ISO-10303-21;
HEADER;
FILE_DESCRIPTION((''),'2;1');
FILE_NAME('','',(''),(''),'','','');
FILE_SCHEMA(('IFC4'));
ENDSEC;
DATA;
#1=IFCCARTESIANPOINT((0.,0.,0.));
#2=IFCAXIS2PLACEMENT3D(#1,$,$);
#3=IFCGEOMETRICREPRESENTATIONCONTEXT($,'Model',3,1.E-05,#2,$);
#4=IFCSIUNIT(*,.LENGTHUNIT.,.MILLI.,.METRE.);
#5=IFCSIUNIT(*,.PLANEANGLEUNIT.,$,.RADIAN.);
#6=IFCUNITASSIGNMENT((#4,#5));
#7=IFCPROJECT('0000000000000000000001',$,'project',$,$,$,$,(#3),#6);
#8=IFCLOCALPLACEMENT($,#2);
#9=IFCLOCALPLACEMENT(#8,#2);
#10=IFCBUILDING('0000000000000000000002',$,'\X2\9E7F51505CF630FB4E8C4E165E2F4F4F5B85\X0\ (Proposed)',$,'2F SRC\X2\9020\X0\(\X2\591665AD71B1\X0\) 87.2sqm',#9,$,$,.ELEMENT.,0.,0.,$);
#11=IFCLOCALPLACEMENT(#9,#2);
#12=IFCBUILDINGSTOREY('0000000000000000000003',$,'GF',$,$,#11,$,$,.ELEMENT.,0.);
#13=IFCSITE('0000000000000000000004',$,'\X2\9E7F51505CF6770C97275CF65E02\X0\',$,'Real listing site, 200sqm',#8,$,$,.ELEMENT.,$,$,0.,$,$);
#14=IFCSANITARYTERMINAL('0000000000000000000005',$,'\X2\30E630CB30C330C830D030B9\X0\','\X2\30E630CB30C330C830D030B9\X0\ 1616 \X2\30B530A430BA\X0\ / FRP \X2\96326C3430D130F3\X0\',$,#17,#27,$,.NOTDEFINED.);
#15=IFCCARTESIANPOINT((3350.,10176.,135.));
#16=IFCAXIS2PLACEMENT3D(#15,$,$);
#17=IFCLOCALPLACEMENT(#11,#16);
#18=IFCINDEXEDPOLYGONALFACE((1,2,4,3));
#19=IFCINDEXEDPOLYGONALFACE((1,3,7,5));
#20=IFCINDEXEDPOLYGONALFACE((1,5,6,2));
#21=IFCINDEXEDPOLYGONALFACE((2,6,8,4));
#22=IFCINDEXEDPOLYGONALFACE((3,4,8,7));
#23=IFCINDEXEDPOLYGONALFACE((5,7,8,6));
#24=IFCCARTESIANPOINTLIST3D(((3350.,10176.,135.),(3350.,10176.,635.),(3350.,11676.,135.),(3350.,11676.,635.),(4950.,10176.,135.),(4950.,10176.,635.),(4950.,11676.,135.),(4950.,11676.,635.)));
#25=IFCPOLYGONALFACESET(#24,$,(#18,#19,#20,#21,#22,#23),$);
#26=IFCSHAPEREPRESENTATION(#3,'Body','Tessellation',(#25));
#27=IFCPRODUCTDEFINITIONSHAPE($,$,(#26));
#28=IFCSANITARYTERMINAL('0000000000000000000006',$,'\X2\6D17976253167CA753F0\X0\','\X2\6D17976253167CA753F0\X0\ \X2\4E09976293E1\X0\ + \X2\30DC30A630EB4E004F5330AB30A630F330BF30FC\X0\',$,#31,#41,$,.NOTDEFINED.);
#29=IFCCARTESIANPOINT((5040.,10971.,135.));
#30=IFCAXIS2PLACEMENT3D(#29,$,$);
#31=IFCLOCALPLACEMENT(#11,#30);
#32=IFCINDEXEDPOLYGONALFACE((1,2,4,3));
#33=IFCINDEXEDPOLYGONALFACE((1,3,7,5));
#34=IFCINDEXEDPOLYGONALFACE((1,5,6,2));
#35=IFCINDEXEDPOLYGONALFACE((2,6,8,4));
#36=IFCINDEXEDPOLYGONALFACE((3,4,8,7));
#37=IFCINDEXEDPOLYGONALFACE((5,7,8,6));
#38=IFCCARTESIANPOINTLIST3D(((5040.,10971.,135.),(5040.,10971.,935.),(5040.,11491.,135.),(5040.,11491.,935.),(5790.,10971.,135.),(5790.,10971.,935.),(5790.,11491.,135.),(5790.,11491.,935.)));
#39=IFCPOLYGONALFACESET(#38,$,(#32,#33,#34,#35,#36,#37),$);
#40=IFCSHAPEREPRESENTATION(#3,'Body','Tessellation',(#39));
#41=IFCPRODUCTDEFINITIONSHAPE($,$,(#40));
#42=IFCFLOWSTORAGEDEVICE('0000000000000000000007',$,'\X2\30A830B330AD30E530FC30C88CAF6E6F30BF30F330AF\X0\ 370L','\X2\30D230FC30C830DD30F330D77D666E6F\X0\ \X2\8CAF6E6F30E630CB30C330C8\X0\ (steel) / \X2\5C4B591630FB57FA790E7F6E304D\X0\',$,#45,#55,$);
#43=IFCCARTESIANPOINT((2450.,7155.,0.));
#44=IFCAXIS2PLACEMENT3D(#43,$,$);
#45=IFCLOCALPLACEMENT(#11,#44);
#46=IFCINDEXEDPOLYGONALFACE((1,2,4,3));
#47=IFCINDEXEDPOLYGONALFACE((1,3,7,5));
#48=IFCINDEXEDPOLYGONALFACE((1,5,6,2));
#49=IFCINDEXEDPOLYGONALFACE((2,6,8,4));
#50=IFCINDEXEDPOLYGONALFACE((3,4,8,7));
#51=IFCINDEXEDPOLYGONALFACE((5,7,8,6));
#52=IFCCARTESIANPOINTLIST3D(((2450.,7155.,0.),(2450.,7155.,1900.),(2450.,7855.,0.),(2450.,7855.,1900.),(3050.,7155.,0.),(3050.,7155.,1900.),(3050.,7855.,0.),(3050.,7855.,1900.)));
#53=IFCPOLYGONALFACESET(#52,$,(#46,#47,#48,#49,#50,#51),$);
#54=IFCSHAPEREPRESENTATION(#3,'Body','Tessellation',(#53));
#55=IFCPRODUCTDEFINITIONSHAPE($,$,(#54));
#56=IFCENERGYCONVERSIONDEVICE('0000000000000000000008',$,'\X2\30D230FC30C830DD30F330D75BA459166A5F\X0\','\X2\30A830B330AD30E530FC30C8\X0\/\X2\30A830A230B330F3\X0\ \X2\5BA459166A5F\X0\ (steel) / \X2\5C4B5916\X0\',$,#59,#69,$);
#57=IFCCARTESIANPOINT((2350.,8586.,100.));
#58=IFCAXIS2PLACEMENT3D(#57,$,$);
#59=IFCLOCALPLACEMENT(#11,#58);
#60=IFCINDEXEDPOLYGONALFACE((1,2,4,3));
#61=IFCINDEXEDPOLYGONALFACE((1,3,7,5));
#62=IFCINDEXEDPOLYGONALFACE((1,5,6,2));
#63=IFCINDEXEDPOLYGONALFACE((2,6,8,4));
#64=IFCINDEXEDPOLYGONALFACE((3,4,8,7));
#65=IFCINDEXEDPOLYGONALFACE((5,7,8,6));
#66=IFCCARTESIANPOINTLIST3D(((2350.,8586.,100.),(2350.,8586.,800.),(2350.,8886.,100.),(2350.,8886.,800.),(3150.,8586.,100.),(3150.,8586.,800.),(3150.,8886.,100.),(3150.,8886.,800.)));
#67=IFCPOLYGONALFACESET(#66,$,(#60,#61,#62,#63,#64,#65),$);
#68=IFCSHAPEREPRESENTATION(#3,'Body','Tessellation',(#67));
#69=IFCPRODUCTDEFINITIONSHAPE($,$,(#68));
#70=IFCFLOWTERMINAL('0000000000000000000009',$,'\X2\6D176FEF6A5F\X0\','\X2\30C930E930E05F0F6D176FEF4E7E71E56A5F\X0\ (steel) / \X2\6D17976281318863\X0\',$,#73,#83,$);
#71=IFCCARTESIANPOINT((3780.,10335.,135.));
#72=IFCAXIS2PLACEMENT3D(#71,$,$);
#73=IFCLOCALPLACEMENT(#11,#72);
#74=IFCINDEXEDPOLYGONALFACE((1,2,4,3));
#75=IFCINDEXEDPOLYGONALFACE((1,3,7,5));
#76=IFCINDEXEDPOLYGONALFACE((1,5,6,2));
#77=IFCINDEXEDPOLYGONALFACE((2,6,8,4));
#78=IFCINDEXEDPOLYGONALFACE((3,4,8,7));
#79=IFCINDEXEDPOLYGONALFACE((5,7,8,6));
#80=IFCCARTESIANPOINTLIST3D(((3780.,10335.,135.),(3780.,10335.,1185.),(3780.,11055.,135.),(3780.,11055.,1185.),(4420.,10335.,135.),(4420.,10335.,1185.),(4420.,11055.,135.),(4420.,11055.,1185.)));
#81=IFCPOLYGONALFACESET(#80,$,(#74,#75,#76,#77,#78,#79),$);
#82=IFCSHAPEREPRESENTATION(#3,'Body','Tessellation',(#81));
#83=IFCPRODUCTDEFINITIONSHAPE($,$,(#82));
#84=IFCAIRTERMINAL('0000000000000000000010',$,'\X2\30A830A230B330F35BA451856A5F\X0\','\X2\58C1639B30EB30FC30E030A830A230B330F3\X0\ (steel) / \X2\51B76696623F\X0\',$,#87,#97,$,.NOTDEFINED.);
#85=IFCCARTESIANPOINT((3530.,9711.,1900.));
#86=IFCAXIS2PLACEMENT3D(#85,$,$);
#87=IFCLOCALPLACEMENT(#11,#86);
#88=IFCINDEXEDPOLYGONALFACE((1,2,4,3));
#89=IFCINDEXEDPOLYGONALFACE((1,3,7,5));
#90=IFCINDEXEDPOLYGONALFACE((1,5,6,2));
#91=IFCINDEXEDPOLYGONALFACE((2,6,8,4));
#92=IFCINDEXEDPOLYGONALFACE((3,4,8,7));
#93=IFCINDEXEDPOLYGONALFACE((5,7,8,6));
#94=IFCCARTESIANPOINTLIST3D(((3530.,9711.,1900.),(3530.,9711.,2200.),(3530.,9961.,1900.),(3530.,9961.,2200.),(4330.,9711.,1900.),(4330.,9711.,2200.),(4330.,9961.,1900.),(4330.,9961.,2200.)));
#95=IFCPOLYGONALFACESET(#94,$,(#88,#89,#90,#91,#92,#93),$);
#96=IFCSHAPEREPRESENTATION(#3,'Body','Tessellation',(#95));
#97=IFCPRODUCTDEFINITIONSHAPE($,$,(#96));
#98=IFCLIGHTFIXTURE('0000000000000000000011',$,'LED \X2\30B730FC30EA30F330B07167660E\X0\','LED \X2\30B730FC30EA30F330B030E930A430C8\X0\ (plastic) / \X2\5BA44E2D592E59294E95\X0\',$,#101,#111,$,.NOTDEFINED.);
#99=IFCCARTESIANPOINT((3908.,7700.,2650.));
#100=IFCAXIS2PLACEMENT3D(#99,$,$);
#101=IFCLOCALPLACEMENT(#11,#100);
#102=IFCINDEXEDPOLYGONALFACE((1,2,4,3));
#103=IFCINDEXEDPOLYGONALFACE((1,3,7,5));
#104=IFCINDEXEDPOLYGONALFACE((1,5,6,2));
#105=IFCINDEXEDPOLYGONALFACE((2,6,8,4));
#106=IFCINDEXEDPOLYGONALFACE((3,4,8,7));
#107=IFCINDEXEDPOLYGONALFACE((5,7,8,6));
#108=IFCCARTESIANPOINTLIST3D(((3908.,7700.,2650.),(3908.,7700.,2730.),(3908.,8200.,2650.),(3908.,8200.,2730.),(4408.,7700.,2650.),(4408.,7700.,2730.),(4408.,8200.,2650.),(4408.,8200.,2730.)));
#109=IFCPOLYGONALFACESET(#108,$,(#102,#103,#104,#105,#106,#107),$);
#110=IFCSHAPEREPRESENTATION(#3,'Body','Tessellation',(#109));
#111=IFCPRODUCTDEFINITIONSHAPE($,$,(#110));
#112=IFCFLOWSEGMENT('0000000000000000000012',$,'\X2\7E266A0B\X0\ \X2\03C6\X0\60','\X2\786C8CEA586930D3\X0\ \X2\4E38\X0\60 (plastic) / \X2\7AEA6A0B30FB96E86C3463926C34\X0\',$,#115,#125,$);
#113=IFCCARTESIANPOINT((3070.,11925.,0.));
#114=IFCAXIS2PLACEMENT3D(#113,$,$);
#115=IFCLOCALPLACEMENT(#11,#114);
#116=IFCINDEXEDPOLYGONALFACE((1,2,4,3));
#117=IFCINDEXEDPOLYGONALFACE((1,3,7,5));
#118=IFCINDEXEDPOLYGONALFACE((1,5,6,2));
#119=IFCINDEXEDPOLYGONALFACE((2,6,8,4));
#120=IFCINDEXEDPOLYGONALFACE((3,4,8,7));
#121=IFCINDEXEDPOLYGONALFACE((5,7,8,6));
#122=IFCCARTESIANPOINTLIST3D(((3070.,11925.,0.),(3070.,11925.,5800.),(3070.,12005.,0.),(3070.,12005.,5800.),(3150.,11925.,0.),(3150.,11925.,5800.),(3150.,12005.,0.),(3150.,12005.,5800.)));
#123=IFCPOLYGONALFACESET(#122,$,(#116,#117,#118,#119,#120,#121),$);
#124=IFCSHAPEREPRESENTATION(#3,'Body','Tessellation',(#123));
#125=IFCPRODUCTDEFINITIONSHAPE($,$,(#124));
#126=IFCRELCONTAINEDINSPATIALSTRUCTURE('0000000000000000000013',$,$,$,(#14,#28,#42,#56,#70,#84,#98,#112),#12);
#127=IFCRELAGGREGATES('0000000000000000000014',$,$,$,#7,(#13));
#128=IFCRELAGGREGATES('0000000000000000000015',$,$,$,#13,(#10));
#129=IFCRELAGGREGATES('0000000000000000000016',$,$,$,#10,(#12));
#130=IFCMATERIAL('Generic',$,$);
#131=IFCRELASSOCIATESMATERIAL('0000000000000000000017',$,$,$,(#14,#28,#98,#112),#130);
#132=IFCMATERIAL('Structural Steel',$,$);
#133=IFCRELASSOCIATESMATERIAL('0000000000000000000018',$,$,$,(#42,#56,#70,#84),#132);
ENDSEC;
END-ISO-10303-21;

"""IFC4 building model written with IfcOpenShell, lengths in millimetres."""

from ifc_helpers import new_model, si_unit, frame, frame_2d, origin, place, context, project, spatial, rectangle, extrude, material, element, save


model = new_model("IFC4")

# Units and contexts
model_context = context("Model", 3, precision=1e-05, world=origin())
ifc_project = project(units=[si_unit("LENGTHUNIT", "METRE", prefix="MILLI"), si_unit("PLANEANGLEUNIT", "RADIAN")], contexts=[model_context])

# Site, building, storey
site_placement = place(None, origin())
site = spatial("IfcSite", under=ifc_project, at=site_placement, Name="鹿児島県霧島市", ObjectType="Real listing site, 200sqm", CompositionType="ELEMENT", RefElevation=0.0)
building_placement = place(site_placement, origin())
building = spatial("IfcBuilding", under=site, at=building_placement, Name="鹿児島・二世帯住宅 (Proposed)", ObjectType="2F SRC造(外断熱) 87.2sqm", CompositionType="ELEMENT", ElevationOfRefHeight=0.0, ElevationOfTerrain=0.0)
storey_placement = place(building_placement, origin())
storey = spatial("IfcBuildingStorey", under=building, at=storey_placement, Name="GF", CompositionType="ELEMENT", Elevation=0.0)

# Shared definitions
ifc_material_1 = material(Name="Generic")

# Sanitary terminals
sanitary_terminal_1_placement = place(storey_placement, frame((3350.0, 10176.0, 135.0)))
element("IfcSanitaryTerminal", 1, at=sanitary_terminal_1_placement, inside=storey, material=ifc_material_1, Name="ユニットバス", Description="ユニットバス 1616 サイズ / FRP 防水パン", PredefinedType="NOTDEFINED", context=model_context, shape_type="SweptSolid", body=[
    extrude(rectangle(XDim=1600.0, YDim=1500.0, at=frame_2d((800.0, 750.0))), frame((3350.0, 10176.0, 135.0)), (0.0, 0.0, 1.0), 500.0),
])
sanitary_terminal_2_placement = place(storey_placement, frame((5040.0, 10971.0, 135.0)))
element("IfcSanitaryTerminal", 2, at=sanitary_terminal_2_placement, inside=storey, material=ifc_material_1, Name="洗面化粧台", Description="洗面化粧台 三面鏡 + ボウル一体カウンター", PredefinedType="NOTDEFINED", context=model_context, shape_type="SweptSolid", body=[
    extrude(rectangle(XDim=750.0, YDim=520.0, at=frame_2d((375.0, 260.0))), frame((5040.0, 10971.0, 135.0)), (0.0, 0.0, 1.0), 800.0),
])

# Flow storage device
ifc_material_2 = material(Name="Structural Steel")
flow_storage_device_placement = place(storey_placement, frame((2450.0, 7155.0, 0.0)))
element("IfcFlowStorageDevice", 3, at=flow_storage_device_placement, inside=storey, material=ifc_material_2, Name="エコキュート貯湯タンク 370L", Description="ヒートポンプ給湯 貯湯ユニット (steel) / 屋外・基礎置き", context=model_context, shape_type="SweptSolid", body=[
    extrude(rectangle(XDim=600.0, YDim=700.0, at=frame_2d((300.0, 350.0))), frame((2450.0, 7155.0, 0.0)), (0.0, 0.0, 1.0), 1900.0),
])

# Energy conversion device
energy_conversion_device_placement = place(storey_placement, frame((2350.0, 8586.0, 100.0)))
element("IfcEnergyConversionDevice", 4, at=energy_conversion_device_placement, inside=storey, material=ifc_material_2, Name="ヒートポンプ室外機", Description="エコキュート/エアコン 室外機 (steel) / 屋外", context=model_context, shape_type="SweptSolid", body=[
    extrude(rectangle(XDim=800.0, YDim=300.0, at=frame_2d((400.0, 150.0))), frame((2350.0, 8586.0, 100.0)), (0.0, 0.0, 1.0), 700.0),
])

# Flow terminal
flow_terminal_placement = place(storey_placement, frame((3780.0, 10335.0, 135.0)))
element("IfcFlowTerminal", 5, at=flow_terminal_placement, inside=storey, material=ifc_material_2, Name="洗濯機", Description="ドラム式洗濯乾燥機 (steel) / 洗面脱衣", context=model_context, shape_type="SweptSolid", body=[
    extrude(rectangle(XDim=640.0, YDim=720.0, at=frame_2d((320.0, 360.0))), frame((3780.0, 10335.0, 135.0)), (0.0, 0.0, 1.0), 1050.0),
])

# Air terminal
air_terminal_placement = place(storey_placement, frame((3530.0, 9711.0, 1900.0)))
element("IfcAirTerminal", 6, at=air_terminal_placement, inside=storey, material=ifc_material_2, Name="エアコン室内機", Description="壁掛ルームエアコン (steel) / 冷暖房", PredefinedType="NOTDEFINED", context=model_context, shape_type="SweptSolid", body=[
    extrude(rectangle(XDim=800.0, YDim=250.0, at=frame_2d((400.0, 125.0))), frame((3530.0, 9711.0, 1900.0)), (0.0, 0.0, 1.0), 300.0),
])

# Light fixture
light_fixture_placement = place(storey_placement, frame((3908.0, 7700.0, 2650.0)))
element("IfcLightFixture", 7, at=light_fixture_placement, inside=storey, material=ifc_material_1, Name="LED シーリング照明", Description="LED シーリングライト (plastic) / 室中央天井", PredefinedType="NOTDEFINED", context=model_context, shape_type="SweptSolid", body=[
    extrude(rectangle(XDim=500.0, YDim=500.0, at=frame_2d((250.0, 250.0))), frame((3908.0, 7700.0, 2650.0)), (0.0, 0.0, 1.0), 80.0),
])

# Flow segment
flow_segment_placement = place(storey_placement, frame((3070.0, 11925.0, 0.0)))
element("IfcFlowSegment", 8, at=flow_segment_placement, inside=storey, material=ifc_material_1, Name="縦樋 φ60", Description="硬質塩ビ 丸60 (plastic) / 竪樋・雨水排水", context=model_context, shape_type="SweptSolid", body=[
    extrude(rectangle(XDim=80.0, YDim=80.0, at=frame_2d((40.0, 40.0))), frame((3070.0, 11925.0, 0.0)), (0.0, 0.0, 1.0), 5800.0),
])

save(model, "model.ifc")
